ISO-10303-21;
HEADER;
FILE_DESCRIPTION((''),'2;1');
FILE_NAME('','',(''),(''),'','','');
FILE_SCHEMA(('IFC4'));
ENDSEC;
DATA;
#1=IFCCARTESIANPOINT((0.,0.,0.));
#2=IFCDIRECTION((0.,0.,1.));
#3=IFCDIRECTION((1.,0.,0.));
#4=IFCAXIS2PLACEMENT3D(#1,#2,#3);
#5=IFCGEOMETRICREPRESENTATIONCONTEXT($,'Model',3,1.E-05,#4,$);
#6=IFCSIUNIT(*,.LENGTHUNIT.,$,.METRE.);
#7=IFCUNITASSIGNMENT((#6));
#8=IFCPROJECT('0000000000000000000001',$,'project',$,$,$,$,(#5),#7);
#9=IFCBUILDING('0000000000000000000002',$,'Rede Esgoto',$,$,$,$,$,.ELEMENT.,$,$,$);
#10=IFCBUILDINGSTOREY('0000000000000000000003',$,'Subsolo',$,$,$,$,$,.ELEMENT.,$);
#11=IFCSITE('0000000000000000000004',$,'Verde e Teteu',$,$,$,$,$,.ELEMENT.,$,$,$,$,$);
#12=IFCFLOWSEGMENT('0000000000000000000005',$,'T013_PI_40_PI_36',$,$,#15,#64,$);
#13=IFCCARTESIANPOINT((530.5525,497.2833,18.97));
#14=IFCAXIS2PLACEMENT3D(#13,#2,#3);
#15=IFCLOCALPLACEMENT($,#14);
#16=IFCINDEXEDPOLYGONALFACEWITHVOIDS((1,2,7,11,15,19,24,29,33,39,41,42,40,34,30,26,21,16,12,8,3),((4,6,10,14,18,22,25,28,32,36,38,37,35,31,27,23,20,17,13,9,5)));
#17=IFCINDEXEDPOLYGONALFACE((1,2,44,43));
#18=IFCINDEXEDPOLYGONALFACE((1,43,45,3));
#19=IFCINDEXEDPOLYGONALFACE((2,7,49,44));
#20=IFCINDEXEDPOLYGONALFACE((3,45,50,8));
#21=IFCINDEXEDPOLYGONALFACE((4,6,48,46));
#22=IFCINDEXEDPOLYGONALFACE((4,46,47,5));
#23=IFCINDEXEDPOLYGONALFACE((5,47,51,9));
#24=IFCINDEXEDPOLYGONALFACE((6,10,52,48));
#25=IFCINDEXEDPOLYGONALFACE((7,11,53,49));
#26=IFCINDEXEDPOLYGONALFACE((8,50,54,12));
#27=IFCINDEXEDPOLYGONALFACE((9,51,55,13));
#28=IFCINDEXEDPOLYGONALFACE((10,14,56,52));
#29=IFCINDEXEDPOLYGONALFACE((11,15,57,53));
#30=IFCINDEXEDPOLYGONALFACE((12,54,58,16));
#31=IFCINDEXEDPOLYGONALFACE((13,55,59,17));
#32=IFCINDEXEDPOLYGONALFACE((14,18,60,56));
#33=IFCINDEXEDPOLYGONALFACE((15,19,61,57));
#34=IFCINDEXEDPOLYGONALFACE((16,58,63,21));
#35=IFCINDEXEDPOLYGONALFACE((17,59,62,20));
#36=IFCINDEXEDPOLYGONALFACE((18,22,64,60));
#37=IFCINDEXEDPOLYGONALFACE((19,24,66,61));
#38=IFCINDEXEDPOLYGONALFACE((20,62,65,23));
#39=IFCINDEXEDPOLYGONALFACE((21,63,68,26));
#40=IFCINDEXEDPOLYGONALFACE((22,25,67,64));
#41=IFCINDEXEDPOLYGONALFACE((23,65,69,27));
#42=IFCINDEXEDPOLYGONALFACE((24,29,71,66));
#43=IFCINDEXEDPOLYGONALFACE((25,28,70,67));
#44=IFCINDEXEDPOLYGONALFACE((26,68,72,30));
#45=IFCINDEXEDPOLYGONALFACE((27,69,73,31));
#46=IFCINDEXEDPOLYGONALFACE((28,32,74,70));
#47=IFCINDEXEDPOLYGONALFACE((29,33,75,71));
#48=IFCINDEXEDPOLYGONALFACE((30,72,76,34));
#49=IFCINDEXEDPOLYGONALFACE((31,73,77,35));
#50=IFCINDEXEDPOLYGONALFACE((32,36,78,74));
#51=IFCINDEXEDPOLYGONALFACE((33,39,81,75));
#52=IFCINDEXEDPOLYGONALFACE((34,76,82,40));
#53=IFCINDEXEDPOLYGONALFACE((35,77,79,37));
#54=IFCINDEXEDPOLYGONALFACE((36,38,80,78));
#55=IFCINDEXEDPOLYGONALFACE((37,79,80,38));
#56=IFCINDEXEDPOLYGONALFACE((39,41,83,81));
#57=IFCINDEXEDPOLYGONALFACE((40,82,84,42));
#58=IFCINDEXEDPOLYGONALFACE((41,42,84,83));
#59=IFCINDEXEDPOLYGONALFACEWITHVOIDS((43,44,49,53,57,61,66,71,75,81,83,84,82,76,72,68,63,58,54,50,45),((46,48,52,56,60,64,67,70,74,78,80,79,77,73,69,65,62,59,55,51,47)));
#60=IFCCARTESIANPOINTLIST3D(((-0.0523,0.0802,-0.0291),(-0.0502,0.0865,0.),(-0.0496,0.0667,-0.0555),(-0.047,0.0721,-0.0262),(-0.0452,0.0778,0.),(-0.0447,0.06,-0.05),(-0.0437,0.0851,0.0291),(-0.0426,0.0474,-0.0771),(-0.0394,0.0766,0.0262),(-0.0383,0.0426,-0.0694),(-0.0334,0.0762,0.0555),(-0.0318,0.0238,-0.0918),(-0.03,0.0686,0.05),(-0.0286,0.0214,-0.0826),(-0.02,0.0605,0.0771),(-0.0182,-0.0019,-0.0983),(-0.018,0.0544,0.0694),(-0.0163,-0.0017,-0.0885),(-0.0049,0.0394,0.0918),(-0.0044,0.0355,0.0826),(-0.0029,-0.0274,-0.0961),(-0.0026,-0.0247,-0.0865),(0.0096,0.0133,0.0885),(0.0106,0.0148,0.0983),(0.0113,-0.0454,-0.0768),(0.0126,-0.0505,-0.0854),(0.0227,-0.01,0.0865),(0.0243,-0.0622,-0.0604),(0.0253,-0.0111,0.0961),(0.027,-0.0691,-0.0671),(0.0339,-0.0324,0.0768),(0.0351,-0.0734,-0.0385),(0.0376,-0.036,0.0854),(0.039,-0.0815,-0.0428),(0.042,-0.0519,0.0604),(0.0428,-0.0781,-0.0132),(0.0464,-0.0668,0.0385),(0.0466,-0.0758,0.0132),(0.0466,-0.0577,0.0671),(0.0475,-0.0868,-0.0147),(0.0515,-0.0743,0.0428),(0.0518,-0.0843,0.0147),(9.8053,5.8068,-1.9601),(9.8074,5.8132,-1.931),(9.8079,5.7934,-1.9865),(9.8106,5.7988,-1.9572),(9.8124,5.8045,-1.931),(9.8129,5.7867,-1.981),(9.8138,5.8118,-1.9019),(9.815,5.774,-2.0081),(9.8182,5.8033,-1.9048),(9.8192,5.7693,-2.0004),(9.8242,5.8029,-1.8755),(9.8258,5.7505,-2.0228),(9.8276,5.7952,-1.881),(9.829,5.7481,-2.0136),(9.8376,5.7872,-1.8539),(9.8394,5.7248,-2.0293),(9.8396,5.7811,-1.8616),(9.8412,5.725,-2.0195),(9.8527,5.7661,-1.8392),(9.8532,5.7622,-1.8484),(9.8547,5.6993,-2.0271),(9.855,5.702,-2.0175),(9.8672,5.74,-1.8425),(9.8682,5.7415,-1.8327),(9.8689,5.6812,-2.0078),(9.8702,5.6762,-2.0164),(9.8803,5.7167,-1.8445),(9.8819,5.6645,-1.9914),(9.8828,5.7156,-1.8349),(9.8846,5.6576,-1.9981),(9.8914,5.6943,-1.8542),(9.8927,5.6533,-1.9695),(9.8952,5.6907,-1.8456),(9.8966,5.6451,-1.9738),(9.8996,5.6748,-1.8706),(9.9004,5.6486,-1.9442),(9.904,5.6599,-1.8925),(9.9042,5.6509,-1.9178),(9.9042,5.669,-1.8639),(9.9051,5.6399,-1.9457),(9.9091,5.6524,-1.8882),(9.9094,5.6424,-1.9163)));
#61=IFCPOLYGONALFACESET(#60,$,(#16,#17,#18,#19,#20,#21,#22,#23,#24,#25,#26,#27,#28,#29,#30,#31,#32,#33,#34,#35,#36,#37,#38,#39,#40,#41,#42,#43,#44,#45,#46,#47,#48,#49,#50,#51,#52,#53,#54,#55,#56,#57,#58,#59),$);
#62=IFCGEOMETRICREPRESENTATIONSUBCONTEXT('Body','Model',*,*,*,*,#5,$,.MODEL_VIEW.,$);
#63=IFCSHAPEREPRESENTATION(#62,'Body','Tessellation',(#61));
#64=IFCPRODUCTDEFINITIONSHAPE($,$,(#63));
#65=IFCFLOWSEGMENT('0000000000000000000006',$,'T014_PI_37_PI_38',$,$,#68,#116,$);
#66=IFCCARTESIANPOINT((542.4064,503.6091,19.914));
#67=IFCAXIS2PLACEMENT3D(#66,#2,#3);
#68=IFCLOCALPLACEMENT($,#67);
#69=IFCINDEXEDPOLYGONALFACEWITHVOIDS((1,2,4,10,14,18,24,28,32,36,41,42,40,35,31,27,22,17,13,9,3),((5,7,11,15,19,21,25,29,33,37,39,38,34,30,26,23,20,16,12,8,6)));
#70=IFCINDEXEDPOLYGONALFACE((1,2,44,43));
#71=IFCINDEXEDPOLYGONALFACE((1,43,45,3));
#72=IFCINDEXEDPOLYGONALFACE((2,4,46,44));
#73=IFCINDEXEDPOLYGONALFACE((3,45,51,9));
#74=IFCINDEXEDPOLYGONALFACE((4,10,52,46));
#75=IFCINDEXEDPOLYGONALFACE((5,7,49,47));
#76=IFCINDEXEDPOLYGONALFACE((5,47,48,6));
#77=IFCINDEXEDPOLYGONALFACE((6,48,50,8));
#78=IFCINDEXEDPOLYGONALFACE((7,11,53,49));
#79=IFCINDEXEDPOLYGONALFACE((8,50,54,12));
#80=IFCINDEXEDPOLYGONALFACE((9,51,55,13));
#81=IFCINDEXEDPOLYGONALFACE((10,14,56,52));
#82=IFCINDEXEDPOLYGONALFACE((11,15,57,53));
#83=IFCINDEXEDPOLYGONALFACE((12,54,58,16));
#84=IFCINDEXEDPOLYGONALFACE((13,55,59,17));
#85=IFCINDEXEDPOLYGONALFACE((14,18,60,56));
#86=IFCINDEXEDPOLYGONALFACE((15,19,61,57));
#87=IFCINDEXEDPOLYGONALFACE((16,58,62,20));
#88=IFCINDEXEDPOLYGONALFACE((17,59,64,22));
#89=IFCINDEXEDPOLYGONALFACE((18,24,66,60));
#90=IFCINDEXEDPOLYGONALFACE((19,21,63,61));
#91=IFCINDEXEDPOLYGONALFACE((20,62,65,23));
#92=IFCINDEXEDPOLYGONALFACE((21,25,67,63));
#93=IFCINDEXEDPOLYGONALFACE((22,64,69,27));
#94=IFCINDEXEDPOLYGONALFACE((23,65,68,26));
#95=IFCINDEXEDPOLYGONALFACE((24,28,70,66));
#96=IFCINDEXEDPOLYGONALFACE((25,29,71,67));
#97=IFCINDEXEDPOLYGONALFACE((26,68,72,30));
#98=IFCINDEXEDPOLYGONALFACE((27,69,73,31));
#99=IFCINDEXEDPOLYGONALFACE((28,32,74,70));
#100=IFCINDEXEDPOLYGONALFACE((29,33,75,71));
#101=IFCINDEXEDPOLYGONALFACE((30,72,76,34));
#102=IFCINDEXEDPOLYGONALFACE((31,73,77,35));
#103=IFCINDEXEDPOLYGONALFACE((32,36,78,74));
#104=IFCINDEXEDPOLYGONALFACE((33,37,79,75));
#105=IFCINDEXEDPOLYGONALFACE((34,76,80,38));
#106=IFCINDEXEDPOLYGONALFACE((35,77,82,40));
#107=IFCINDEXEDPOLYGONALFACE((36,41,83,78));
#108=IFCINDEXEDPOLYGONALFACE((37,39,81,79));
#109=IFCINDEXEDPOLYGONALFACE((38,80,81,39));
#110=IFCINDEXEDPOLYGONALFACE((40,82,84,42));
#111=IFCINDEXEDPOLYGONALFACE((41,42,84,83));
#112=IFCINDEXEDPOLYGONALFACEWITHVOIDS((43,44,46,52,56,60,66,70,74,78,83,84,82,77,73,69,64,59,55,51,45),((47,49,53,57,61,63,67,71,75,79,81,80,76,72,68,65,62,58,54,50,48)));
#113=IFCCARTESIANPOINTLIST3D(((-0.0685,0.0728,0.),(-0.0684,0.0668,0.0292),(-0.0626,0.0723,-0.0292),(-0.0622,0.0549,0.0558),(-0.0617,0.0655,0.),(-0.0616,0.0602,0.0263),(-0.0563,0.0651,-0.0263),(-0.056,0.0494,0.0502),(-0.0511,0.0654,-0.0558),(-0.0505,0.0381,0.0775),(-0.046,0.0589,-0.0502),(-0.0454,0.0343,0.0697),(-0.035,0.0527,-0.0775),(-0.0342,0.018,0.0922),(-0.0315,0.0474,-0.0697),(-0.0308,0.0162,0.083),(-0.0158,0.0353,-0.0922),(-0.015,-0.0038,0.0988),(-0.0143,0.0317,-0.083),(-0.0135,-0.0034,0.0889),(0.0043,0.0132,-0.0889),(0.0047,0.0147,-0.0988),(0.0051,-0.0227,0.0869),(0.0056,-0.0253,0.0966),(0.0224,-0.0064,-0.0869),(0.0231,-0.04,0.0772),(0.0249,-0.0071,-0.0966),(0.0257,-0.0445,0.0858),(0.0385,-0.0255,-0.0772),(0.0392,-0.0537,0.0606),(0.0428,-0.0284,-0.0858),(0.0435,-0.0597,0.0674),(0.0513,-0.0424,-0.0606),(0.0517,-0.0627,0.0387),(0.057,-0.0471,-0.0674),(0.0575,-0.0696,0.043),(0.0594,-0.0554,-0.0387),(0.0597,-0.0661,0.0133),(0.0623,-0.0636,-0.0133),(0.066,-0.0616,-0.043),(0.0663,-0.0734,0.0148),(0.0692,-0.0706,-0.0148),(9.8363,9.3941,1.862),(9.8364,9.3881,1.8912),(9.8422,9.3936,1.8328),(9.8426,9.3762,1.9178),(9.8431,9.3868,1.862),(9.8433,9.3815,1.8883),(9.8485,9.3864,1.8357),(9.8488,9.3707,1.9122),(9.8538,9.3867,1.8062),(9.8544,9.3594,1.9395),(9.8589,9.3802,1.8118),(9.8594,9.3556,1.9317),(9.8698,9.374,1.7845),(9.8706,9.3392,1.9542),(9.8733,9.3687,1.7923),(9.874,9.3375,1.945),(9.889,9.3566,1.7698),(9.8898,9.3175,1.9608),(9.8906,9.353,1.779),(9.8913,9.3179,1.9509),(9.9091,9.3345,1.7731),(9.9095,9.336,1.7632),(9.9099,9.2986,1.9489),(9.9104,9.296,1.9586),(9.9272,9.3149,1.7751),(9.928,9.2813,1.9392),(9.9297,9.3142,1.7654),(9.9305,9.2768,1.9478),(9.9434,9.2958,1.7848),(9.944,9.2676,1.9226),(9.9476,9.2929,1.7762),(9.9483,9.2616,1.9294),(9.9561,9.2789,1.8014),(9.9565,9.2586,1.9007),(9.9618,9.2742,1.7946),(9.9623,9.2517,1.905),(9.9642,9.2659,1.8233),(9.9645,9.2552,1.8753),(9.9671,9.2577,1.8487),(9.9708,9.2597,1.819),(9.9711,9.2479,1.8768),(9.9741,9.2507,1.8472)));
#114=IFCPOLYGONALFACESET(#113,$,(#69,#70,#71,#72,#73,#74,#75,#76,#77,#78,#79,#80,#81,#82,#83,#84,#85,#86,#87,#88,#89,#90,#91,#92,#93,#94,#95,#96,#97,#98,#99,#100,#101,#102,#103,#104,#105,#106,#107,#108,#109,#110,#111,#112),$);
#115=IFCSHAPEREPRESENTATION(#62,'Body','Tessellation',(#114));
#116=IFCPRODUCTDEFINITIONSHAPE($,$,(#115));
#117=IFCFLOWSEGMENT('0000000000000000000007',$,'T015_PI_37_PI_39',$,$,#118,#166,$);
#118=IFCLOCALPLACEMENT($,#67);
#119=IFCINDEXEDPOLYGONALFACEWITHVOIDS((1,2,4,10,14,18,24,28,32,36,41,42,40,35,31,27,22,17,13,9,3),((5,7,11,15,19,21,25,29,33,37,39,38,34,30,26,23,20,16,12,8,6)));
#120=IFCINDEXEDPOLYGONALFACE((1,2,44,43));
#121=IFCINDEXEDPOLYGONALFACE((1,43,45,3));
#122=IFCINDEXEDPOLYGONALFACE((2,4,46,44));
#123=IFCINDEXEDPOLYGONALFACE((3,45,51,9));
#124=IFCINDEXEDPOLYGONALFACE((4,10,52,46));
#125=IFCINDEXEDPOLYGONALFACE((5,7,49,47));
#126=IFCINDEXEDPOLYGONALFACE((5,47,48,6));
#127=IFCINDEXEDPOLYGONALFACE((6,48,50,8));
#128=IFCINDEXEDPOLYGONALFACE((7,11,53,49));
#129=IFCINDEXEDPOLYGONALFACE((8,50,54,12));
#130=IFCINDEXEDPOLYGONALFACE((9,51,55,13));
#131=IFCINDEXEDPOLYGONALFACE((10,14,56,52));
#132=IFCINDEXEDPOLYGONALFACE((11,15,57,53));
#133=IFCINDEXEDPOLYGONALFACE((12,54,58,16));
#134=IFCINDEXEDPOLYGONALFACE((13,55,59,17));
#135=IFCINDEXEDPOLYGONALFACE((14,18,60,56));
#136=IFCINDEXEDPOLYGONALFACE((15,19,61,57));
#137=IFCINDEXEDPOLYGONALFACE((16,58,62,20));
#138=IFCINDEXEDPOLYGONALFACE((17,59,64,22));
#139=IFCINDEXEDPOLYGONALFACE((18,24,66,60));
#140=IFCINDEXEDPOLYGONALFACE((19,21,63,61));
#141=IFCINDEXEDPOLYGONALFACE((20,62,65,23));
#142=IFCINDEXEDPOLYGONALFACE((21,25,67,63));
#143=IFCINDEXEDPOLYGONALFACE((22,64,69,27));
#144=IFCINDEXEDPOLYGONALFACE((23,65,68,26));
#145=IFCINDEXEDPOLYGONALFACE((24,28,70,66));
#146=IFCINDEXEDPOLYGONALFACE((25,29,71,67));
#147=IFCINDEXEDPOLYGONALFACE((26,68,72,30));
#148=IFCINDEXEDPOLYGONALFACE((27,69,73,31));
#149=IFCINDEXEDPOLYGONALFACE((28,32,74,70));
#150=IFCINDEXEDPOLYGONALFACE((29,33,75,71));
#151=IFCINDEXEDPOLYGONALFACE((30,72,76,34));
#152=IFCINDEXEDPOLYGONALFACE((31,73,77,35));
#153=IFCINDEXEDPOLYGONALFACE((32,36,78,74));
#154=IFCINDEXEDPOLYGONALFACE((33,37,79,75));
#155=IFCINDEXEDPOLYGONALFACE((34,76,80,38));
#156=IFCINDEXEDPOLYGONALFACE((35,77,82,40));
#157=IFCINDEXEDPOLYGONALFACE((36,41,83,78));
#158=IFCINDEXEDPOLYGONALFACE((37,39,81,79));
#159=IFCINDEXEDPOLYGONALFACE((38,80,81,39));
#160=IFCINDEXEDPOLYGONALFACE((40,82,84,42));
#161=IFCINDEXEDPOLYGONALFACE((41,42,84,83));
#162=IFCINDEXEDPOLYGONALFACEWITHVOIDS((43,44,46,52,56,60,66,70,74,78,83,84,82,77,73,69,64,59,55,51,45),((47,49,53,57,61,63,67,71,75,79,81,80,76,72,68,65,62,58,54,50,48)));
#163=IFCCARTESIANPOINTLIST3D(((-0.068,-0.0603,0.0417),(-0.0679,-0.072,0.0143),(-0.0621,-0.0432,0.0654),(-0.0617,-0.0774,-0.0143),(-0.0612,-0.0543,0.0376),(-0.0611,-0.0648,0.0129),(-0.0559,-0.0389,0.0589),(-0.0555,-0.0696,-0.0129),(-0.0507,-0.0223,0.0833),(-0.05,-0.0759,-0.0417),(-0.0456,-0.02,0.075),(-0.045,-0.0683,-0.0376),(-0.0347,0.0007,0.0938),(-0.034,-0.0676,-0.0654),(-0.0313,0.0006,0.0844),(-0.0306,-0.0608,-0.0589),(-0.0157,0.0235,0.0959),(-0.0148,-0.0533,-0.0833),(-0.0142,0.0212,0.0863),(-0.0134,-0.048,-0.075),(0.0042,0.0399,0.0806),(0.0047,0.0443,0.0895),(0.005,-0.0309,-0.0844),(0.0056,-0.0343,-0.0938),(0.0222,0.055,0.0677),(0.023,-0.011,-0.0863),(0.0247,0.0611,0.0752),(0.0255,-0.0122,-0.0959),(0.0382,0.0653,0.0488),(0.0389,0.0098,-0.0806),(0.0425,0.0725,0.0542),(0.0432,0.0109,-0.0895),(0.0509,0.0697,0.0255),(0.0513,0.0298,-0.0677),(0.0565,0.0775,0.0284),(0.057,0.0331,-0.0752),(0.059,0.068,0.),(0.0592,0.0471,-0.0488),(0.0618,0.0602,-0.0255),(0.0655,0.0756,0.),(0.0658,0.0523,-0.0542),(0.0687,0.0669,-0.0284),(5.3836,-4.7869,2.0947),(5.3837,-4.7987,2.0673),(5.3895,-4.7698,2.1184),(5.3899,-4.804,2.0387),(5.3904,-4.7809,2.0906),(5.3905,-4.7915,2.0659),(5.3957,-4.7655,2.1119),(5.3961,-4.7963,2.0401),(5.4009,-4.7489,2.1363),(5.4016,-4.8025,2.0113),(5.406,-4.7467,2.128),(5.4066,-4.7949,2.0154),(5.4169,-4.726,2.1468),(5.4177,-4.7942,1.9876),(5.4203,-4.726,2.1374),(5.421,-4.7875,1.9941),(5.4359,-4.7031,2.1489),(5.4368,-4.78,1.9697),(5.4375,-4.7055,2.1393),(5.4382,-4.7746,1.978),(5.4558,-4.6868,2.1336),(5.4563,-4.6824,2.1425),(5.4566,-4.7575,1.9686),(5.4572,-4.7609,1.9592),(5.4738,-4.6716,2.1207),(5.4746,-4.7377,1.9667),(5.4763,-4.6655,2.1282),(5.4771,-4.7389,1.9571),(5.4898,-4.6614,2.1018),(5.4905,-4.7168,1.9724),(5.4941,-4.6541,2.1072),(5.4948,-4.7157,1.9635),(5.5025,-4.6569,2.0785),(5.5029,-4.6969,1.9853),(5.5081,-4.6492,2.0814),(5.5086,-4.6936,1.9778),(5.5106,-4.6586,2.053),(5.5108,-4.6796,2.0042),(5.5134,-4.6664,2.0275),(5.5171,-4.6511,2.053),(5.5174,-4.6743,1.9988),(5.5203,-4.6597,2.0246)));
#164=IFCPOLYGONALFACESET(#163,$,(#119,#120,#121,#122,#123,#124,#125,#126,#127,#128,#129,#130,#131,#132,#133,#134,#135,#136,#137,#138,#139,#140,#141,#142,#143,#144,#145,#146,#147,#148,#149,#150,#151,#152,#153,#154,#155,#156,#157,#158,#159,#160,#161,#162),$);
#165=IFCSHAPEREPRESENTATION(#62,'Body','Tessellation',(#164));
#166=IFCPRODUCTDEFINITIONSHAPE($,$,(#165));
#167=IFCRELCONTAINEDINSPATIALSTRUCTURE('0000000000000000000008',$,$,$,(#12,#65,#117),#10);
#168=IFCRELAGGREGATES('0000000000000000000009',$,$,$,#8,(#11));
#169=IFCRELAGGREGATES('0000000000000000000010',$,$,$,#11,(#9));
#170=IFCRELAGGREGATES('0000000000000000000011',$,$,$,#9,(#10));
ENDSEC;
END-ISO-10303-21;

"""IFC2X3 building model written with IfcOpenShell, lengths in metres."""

from ifc_helpers import new_model, entity, si_unit, frame, origin_with_axes, place, context, subcontext, project, spatial, element, save


model = new_model("IFC2X3")

# Units and contexts
model_context = context("Model", 3, precision=1e-05, world=origin_with_axes())
body_context = subcontext(model_context, "Body", "Model", "MODEL_VIEW")
ifc_project = project(units=[si_unit("LENGTHUNIT", "METRE")], contexts=[model_context])

# Site, building, storey
site = spatial("IfcSite", under=ifc_project, Name="Verde e Teteu", CompositionType="ELEMENT")
building = spatial("IfcBuilding", under=site, Name="Rede Esgoto", CompositionType="ELEMENT")
storey = spatial("IfcBuildingStorey", under=building, Name="Subsolo", CompositionType="ELEMENT")

# Flow segments
flow_segment_1_placement = place(None, frame((530.5525, 497.2833, 18.97), z_axis=(0.0, 0.0, 1.0), x_axis=(1.0, 0.0, 0.0)))
element("IfcFlowSegment", 1, at=flow_segment_1_placement, inside=storey, Name="T013_PI_40_PI_36", context=body_context, shape_type="SweptSolid", body=[
    entity("IfcSweptDiskSolid", entity("IfcPolyline", [entity("IfcCartesianPoint", [0.0, 0.0, 0.0]), entity("IfcCartesianPoint", [9.8576, 5.7267, -1.931])]), 0.1, 0.09),
])
flow_segment_2_placement = place(None, frame((542.4064, 503.6091, 19.914), z_axis=(0.0, 0.0, 1.0), x_axis=(1.0, 0.0, 0.0)))
element("IfcFlowSegment", 2, at=flow_segment_2_placement, inside=storey, Name="T014_PI_37_PI_38", context=body_context, shape_type="SweptSolid", body=[
    entity("IfcSweptDiskSolid", entity("IfcPolyline", [entity("IfcCartesianPoint", [0.0, 0.0, 0.0]), entity("IfcCartesianPoint", [9.9048, 9.3213, 1.862])]), 0.1, 0.09),
])
flow_segment_3_placement = place(None, frame((542.4064, 503.6091, 19.914), z_axis=(0.0, 0.0, 1.0), x_axis=(1.0, 0.0, 0.0)))
element("IfcFlowSegment", 3, at=flow_segment_3_placement, inside=storey, Name="T015_PI_37_PI_39", context=body_context, shape_type="SweptSolid", body=[
    entity("IfcSweptDiskSolid", entity("IfcPolyline", [entity("IfcCartesianPoint", [0.0, 0.0, 0.0]), entity("IfcCartesianPoint", [5.4516, -4.7266, 2.053])]), 0.1, 0.09),
])

save(model, "model.ifc")
